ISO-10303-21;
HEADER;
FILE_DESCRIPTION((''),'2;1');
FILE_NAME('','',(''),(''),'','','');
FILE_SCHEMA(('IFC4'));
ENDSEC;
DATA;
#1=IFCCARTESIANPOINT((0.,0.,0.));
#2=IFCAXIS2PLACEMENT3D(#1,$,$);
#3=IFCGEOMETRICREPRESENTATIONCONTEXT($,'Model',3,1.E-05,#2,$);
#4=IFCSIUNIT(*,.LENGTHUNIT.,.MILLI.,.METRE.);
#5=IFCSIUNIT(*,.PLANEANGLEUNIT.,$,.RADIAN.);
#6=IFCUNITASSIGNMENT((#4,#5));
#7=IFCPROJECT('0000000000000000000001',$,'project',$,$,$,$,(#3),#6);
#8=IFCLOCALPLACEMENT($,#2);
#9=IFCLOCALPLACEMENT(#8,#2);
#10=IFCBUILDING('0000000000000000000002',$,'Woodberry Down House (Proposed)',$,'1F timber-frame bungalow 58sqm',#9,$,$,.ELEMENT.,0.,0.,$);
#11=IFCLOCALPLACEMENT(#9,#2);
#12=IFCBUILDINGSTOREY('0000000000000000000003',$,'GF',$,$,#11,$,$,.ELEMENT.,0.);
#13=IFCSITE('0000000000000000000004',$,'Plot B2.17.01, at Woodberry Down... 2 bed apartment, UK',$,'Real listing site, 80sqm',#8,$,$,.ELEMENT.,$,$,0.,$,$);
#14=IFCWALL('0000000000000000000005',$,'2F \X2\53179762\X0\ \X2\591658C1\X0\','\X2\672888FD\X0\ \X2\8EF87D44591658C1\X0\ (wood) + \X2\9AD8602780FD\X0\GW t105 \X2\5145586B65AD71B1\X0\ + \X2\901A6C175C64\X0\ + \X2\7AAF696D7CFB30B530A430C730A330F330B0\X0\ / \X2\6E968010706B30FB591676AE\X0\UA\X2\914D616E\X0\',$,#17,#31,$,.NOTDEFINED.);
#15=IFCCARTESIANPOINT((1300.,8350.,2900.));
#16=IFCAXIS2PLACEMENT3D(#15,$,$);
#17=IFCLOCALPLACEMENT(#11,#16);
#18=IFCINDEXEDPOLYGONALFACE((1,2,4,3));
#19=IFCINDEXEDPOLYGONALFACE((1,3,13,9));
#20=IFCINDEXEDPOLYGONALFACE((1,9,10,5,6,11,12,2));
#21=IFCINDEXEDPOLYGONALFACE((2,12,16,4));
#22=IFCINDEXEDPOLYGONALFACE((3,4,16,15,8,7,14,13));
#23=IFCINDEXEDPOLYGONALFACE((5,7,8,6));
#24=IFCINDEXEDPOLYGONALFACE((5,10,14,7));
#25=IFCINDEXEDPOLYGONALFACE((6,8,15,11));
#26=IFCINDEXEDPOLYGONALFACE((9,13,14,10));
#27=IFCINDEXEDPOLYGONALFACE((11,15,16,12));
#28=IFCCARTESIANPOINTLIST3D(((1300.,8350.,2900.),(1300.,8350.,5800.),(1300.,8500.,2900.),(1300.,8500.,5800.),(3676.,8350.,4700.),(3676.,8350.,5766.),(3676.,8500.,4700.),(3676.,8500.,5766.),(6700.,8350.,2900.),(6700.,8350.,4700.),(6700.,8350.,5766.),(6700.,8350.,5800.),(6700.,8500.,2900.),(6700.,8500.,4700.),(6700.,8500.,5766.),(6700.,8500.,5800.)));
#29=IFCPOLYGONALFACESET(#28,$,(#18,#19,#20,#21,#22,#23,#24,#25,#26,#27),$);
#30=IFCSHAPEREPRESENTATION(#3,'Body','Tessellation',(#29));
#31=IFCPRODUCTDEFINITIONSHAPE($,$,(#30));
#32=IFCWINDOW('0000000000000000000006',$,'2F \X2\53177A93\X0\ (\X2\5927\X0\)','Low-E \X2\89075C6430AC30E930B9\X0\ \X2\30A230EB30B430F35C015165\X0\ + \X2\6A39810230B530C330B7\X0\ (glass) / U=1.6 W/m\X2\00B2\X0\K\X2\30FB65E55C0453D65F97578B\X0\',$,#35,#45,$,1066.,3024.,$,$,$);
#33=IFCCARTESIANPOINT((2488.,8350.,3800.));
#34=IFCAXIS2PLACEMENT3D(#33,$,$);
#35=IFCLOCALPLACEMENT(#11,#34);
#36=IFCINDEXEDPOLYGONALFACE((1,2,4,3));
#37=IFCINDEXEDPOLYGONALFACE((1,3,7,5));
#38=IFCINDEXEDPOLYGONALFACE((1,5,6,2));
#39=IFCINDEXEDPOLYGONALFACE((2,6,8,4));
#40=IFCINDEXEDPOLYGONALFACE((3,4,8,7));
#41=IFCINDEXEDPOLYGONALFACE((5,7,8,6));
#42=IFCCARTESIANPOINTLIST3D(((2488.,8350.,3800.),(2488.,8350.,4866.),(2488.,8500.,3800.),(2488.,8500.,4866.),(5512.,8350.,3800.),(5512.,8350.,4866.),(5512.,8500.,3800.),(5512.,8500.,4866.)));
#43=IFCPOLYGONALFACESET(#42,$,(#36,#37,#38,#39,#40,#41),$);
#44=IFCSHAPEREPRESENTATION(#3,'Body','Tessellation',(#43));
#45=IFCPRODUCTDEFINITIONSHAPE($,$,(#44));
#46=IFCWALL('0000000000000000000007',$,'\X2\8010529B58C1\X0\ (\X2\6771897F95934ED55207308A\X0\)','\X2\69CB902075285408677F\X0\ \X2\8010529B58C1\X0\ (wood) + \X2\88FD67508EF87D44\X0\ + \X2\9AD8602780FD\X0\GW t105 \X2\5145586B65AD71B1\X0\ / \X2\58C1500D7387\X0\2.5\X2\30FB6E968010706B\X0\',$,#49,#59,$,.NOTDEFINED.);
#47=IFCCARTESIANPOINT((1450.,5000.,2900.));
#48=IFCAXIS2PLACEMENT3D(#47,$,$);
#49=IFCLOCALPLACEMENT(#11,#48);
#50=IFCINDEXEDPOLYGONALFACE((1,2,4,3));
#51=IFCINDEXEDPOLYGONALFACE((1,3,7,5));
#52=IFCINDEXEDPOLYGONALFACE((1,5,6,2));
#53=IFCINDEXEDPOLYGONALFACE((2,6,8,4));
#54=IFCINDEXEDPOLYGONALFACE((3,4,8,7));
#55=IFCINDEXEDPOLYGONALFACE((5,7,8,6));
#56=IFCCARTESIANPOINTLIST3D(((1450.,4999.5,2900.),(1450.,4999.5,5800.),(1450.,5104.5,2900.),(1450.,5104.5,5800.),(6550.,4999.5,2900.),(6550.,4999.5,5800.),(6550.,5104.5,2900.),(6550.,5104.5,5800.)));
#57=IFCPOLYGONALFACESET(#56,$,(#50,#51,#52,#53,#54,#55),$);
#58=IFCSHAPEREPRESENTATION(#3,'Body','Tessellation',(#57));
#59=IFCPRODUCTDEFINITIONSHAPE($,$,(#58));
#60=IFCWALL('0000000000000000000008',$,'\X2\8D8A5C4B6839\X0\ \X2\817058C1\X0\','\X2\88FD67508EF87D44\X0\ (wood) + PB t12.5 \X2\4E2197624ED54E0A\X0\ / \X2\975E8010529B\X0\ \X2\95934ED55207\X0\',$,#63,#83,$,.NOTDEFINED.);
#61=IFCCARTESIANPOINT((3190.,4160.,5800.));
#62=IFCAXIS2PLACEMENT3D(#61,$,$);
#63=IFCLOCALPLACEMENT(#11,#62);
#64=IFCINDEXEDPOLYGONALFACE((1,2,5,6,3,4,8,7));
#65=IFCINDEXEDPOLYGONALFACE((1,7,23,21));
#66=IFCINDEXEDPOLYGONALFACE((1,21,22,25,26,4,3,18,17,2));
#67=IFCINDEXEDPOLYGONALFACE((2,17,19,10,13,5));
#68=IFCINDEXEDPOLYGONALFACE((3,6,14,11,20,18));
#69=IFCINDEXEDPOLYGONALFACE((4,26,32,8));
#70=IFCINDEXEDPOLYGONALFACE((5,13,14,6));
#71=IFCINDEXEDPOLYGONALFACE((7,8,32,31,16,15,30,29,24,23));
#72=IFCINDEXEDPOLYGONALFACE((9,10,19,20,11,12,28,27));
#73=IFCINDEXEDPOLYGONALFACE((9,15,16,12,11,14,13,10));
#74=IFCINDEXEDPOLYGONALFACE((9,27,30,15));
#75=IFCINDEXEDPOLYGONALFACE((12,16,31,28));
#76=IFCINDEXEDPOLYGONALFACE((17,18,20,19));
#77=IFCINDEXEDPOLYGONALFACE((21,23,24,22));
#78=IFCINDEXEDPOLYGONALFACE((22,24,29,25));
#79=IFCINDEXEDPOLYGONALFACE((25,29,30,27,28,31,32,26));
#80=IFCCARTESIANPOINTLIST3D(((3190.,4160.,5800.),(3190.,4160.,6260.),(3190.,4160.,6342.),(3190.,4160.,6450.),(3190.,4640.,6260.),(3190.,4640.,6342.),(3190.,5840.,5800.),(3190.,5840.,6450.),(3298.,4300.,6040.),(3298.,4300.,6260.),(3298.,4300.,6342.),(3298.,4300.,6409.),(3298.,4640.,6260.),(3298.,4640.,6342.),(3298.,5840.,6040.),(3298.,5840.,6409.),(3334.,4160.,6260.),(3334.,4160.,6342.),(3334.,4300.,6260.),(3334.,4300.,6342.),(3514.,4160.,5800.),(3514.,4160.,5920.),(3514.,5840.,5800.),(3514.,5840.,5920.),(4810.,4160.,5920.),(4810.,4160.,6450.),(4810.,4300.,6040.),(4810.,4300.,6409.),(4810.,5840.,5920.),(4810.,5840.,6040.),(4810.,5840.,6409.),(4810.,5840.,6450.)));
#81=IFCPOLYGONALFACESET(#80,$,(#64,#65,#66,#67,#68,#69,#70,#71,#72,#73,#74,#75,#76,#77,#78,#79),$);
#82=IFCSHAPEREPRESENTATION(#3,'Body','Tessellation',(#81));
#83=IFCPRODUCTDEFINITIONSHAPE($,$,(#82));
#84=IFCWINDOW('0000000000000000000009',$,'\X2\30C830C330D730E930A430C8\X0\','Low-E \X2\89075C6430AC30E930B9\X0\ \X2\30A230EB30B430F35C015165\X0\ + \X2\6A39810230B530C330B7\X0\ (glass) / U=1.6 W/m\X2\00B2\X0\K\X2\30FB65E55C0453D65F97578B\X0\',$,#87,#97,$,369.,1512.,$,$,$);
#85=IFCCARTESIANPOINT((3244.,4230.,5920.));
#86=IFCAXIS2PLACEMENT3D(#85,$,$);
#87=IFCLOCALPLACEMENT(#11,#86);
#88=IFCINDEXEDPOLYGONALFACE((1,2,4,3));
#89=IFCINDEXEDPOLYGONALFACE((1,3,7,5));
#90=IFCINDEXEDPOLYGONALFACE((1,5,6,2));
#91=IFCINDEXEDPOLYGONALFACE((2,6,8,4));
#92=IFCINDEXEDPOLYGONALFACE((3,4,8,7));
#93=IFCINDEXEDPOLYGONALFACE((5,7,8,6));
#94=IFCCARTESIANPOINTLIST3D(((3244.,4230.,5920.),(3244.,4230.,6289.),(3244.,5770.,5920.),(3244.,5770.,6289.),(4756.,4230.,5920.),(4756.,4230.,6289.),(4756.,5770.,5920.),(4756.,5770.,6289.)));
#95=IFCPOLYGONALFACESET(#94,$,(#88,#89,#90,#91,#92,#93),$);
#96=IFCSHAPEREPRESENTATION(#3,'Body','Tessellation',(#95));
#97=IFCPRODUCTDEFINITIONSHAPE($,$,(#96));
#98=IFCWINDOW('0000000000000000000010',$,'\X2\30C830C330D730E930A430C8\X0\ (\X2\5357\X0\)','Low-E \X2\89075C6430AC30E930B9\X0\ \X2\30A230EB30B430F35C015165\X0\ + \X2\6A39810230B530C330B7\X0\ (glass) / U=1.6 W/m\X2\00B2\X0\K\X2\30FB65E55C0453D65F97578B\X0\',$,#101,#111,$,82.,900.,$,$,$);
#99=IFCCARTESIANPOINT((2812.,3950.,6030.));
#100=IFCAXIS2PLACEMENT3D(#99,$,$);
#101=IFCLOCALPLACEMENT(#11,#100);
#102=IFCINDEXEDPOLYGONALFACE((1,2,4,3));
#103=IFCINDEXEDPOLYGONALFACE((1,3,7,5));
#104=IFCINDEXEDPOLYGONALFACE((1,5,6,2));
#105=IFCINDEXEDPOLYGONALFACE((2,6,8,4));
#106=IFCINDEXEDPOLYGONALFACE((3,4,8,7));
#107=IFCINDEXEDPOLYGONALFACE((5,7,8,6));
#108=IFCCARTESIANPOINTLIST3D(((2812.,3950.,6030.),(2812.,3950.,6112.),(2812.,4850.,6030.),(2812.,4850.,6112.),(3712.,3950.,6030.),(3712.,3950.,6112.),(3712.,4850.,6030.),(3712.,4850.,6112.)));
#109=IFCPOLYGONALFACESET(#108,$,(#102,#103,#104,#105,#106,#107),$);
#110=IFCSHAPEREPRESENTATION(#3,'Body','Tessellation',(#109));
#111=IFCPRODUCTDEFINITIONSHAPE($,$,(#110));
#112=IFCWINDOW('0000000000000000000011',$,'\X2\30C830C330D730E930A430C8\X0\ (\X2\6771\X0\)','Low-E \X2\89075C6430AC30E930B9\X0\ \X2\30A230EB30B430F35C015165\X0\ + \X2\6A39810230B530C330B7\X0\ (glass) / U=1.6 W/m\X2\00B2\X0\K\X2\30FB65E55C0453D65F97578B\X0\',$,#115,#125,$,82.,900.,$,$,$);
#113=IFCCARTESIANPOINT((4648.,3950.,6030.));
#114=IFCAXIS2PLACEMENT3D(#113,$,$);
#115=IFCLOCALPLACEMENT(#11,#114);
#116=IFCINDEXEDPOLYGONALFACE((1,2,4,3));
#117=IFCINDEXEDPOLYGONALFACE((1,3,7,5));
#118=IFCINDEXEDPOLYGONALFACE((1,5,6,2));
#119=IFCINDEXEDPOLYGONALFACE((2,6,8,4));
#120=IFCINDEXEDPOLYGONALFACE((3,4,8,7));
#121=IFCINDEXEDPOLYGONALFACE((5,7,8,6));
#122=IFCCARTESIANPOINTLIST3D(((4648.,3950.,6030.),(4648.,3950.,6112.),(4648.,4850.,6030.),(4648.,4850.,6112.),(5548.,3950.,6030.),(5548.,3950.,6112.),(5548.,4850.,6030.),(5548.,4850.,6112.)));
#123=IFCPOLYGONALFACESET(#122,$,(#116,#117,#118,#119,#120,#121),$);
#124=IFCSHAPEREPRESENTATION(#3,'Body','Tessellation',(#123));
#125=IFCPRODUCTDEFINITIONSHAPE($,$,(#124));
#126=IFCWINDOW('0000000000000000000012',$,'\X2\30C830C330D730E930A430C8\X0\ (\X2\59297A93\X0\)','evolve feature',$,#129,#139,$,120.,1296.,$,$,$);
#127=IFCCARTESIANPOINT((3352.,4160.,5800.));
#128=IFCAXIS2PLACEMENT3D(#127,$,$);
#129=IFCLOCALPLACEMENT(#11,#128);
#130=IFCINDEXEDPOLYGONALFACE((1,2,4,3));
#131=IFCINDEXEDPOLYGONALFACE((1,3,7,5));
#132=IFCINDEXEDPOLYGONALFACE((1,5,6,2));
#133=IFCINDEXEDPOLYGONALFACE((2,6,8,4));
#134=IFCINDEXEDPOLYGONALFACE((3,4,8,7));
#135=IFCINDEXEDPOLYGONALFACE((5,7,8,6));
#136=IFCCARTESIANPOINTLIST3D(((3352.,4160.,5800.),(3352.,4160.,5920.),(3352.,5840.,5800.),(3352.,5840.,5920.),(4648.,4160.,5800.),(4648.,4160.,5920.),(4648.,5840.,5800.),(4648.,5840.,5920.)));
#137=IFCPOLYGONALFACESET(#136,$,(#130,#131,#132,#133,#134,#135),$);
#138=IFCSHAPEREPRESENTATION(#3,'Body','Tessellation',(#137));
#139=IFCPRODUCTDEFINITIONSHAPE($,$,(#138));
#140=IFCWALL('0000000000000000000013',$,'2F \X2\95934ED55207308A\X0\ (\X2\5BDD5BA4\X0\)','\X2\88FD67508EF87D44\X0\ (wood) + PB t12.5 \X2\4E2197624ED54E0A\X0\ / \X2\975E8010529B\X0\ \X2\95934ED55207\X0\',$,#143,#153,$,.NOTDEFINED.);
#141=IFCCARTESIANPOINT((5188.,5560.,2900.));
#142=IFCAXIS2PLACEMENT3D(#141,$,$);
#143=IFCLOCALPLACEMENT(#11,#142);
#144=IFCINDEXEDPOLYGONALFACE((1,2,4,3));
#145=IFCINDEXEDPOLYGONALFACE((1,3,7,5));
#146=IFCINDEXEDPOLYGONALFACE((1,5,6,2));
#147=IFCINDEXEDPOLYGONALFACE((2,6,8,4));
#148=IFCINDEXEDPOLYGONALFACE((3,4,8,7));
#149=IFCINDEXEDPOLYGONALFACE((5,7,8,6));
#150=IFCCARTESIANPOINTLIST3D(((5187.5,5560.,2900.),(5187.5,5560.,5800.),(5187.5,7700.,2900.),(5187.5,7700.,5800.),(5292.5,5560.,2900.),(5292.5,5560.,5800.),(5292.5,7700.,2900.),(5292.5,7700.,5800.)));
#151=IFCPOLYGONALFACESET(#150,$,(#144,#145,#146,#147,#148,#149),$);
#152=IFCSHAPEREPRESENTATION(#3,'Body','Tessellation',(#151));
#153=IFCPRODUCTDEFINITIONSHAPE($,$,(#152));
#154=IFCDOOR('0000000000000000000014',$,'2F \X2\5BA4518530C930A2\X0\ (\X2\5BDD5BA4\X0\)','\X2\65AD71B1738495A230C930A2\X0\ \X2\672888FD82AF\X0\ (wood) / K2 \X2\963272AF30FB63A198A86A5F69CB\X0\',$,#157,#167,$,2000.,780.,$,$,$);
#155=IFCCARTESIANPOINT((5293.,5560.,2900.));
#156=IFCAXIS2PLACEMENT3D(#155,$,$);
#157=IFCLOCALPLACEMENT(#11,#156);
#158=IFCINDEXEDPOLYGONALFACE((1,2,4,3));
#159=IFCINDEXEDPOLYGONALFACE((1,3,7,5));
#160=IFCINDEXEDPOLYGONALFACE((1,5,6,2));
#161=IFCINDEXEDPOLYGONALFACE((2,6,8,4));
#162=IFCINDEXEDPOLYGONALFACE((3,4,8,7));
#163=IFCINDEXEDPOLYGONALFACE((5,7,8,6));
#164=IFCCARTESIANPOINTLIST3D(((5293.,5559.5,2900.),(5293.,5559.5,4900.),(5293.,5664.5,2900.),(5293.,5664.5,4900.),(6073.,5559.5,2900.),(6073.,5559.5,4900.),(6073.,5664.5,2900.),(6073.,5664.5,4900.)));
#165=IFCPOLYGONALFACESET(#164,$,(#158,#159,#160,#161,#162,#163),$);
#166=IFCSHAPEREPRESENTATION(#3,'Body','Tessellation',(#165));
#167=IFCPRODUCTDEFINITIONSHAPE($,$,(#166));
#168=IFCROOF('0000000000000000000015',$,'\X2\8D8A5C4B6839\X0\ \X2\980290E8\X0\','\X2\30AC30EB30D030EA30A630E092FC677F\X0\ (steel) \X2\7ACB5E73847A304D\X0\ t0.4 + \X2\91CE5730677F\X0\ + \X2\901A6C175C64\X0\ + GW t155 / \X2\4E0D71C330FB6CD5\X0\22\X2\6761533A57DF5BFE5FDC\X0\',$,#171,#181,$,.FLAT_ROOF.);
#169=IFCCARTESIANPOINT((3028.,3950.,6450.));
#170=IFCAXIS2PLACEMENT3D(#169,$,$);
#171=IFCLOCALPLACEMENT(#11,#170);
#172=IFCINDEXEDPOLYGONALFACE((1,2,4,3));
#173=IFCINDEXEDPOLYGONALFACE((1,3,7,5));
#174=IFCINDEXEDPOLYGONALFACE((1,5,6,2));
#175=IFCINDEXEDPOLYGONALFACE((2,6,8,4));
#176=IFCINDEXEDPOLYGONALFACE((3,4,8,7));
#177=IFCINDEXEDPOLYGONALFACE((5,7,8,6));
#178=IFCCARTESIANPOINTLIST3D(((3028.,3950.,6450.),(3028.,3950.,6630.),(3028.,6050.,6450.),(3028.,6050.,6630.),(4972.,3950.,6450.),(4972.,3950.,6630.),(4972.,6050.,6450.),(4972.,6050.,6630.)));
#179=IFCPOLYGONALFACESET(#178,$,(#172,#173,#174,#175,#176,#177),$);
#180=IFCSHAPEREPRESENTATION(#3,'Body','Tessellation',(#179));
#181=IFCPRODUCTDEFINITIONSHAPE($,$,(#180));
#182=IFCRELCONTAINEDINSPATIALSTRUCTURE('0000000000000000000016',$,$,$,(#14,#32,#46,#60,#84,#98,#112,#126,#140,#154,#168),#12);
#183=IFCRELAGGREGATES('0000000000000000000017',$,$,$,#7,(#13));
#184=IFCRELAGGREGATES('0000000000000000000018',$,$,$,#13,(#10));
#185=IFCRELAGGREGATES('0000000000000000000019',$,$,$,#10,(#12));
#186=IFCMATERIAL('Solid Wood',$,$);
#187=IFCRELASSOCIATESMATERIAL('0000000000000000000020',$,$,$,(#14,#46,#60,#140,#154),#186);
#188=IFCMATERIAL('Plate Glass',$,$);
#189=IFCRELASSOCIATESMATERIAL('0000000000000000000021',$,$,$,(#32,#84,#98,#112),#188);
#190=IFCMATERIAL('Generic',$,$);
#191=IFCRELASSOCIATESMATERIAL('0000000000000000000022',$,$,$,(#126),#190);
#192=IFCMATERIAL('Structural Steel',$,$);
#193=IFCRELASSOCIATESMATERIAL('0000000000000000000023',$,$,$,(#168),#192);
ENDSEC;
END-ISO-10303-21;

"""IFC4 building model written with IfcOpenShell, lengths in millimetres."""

from ifc_helpers import new_model, si_unit, frame, frame_2d, origin, place, context, project, spatial, rectangle, extrude, material, element, fill, save


model = new_model("IFC4")

# Units and contexts
model_context = context("Model", 3, precision=1e-05, world=origin())
ifc_project = project(units=[si_unit("LENGTHUNIT", "METRE", prefix="MILLI"), si_unit("PLANEANGLEUNIT", "RADIAN")], contexts=[model_context])

# Site, building, storey
site_placement = place(None, origin())
site = spatial("IfcSite", under=ifc_project, at=site_placement, Name="Plot B2.17.01, at Woodberry Down... 2 bed apartment, UK", ObjectType="Real listing site, 80sqm", CompositionType="ELEMENT", RefElevation=0.0)
building_placement = place(site_placement, origin())
building = spatial("IfcBuilding", under=site, at=building_placement, Name="Woodberry Down House (Proposed)", ObjectType="1F timber-frame bungalow 58sqm", CompositionType="ELEMENT", ElevationOfRefHeight=0.0, ElevationOfTerrain=0.0)
storey_placement = place(building_placement, origin())
storey = spatial("IfcBuildingStorey", under=building, at=storey_placement, Name="GF", CompositionType="ELEMENT", Elevation=0.0)

# Wall, opening, window
ifc_material_1 = material(Name="Solid Wood")
wall_1_placement = place(storey_placement, frame((1300.0, 8350.0, 2900.0)))
wall_1 = element("IfcWall", 1, at=wall_1_placement, inside=storey, material=ifc_material_1, Name="2F 北面 外壁", Description="木製 軸組外壁 (wood) + 高性能GW t105 充填断熱 + 通気層 + 窯業系サイディング / 準耐火・外皮UA配慮", PredefinedType="NOTDEFINED", context=model_context, shape_type="SweptSolid", body=[
    extrude(rectangle(XDim=5400.0, YDim=150.0, at=frame_2d((2700.0, 75.0))), frame((1300.0, 8350.0, 2900.0)), (0.0, 0.0, 1.0), 2900.0),
])
opening_1_placement = place(storey_placement, frame((2488.0, 8350.0, 3800.0)))
opening_1 = element("IfcOpeningElement", 2, at=opening_1_placement, cuts=wall_1, PredefinedType="NOTDEFINED", context=model_context, shape_type="SweptSolid", body=[
    extrude(rectangle(XDim=3024.0, YDim=150.0, at=frame_2d((1512.0, 75.0))), frame((2488.0, 8350.0, 3800.0)), (0.0, 0.0, 1.0), 1066.0),
])
ifc_material_2 = material(Name="Plate Glass")
window_1_placement = place(storey_placement, frame((2488.0, 8350.0, 3800.0)))
window_1 = element("IfcWindow", 3, at=window_1_placement, inside=storey, material=ifc_material_2, Name="2F 北窓 (大)", Description="Low-E 複層ガラス アルゴン封入 + 樹脂サッシ (glass) / U=1.6 W/m²K・日射取得型", OverallHeight=1066.0, OverallWidth=3024.0, context=model_context, shape_type="SweptSolid", body=[
    extrude(rectangle(XDim=3024.0, YDim=150.0, at=frame_2d((1512.0, 75.0))), frame((2488.0, 8350.0, 3800.0)), (0.0, 0.0, 1.0), 1066.0),
])
fill(opening_1, window_1)

# Wall
wall_2_placement = place(storey_placement, frame((1450.0, 5000.0, 2900.0)))
element("IfcWall", 4, at=wall_2_placement, inside=storey, material=ifc_material_1, Name="耐力壁 (東西間仕切り)", Description="構造用合板 耐力壁 (wood) + 製材軸組 + 高性能GW t105 充填断熱 / 壁倍率2.5・準耐火", PredefinedType="NOTDEFINED", context=model_context, shape_type="SweptSolid", body=[
    extrude(rectangle(XDim=5100.0, YDim=105.0, at=frame_2d((2550.0, 52.0))), frame((1450.0, 5000.0, 2900.0)), (0.0, 0.0, 1.0), 2900.0),
])

# Wall, openings, windows
wall_3_placement = place(storey_placement, frame((3190.0, 4160.0, 5800.0)))
wall_3 = element("IfcWall", 5, at=wall_3_placement, inside=storey, material=ifc_material_1, Name="越屋根 腰壁", Description="製材軸組 (wood) + PB t12.5 両面仕上 / 非耐力 間仕切", PredefinedType="NOTDEFINED", context=model_context, shape_type="SweptSolid", body=[
    extrude(rectangle(XDim=1620.0, YDim=1680.0, at=frame_2d((810.0, 840.0))), frame((3190.0, 4160.0, 5800.0)), (0.0, 0.0, 1.0), 650.0),
])
opening_2_placement = place(storey_placement, frame((3244.0, 4230.0, 5920.0)))
opening_2 = element("IfcOpeningElement", 6, at=opening_2_placement, cuts=wall_3, PredefinedType="NOTDEFINED", context=model_context, shape_type="SweptSolid", body=[
    extrude(rectangle(XDim=1512.0, YDim=1540.0, at=frame_2d((756.0, 770.0))), frame((3244.0, 4230.0, 5920.0)), (0.0, 0.0, 1.0), 369.0),
])
opening_3_placement = place(storey_placement, frame((2812.0, 3950.0, 6030.0)))
opening_3 = element("IfcOpeningElement", 7, at=opening_3_placement, cuts=wall_3, PredefinedType="NOTDEFINED", context=model_context, shape_type="SweptSolid", body=[
    extrude(rectangle(XDim=900.0, YDim=900.0, at=frame_2d((450.0, 450.0))), frame((2812.0, 3950.0, 6030.0)), (0.0, 0.0, 1.0), 82.0),
])
opening_4_placement = place(storey_placement, frame((4648.0, 3950.0, 6030.0)))
opening_4 = element("IfcOpeningElement", 8, at=opening_4_placement, cuts=wall_3, PredefinedType="NOTDEFINED", context=model_context, shape_type="SweptSolid", body=[
    extrude(rectangle(XDim=900.0, YDim=900.0, at=frame_2d((450.0, 450.0))), frame((4648.0, 3950.0, 6030.0)), (0.0, 0.0, 1.0), 82.0),
])
opening_5_placement = place(storey_placement, frame((3352.0, 4160.0, 5800.0)))
opening_5 = element("IfcOpeningElement", 9, at=opening_5_placement, cuts=wall_3, PredefinedType="NOTDEFINED", context=model_context, shape_type="SweptSolid", body=[
    extrude(rectangle(XDim=1296.0, YDim=1680.0, at=frame_2d((648.0, 840.0))), frame((3352.0, 4160.0, 5800.0)), (0.0, 0.0, 1.0), 120.0),
])
window_2_placement = place(storey_placement, frame((3244.0, 4230.0, 5920.0)))
window_2 = element("IfcWindow", 10, at=window_2_placement, inside=storey, material=ifc_material_2, Name="トップライト", Description="Low-E 複層ガラス アルゴン封入 + 樹脂サッシ (glass) / U=1.6 W/m²K・日射取得型", OverallHeight=369.0, OverallWidth=1512.0, context=model_context, shape_type="SweptSolid", body=[
    extrude(rectangle(XDim=1512.0, YDim=1540.0, at=frame_2d((756.0, 770.0))), frame((3244.0, 4230.0, 5920.0)), (0.0, 0.0, 1.0), 369.0),
])
fill(opening_2, window_2)
window_3_placement = place(storey_placement, frame((2812.0, 3950.0, 6030.0)))
window_3 = element("IfcWindow", 11, at=window_3_placement, inside=storey, material=ifc_material_2, Name="トップライト (南)", Description="Low-E 複層ガラス アルゴン封入 + 樹脂サッシ (glass) / U=1.6 W/m²K・日射取得型", OverallHeight=82.0, OverallWidth=900.0, context=model_context, shape_type="SweptSolid", body=[
    extrude(rectangle(XDim=900.0, YDim=900.0, at=frame_2d((450.0, 450.0))), frame((2812.0, 3950.0, 6030.0)), (0.0, 0.0, 1.0), 82.0),
])
fill(opening_3, window_3)
window_4_placement = place(storey_placement, frame((4648.0, 3950.0, 6030.0)))
window_4 = element("IfcWindow", 12, at=window_4_placement, inside=storey, material=ifc_material_2, Name="トップライト (東)", Description="Low-E 複層ガラス アルゴン封入 + 樹脂サッシ (glass) / U=1.6 W/m²K・日射取得型", OverallHeight=82.0, OverallWidth=900.0, context=model_context, shape_type="SweptSolid", body=[
    extrude(rectangle(XDim=900.0, YDim=900.0, at=frame_2d((450.0, 450.0))), frame((4648.0, 3950.0, 6030.0)), (0.0, 0.0, 1.0), 82.0),
])
fill(opening_4, window_4)
ifc_material_3 = material(Name="Generic")
window_5_placement = place(storey_placement, frame((3352.0, 4160.0, 5800.0)))
window_5 = element("IfcWindow", 13, at=window_5_placement, inside=storey, material=ifc_material_3, Name="トップライト (天窓)", Description="evolve feature", OverallHeight=120.0, OverallWidth=1296.0, context=model_context, shape_type="SweptSolid", body=[
    extrude(rectangle(XDim=1296.0, YDim=1680.0, at=frame_2d((648.0, 840.0))), frame((3352.0, 4160.0, 5800.0)), (0.0, 0.0, 1.0), 120.0),
])
fill(opening_5, window_5)

# Wall
wall_4_placement = place(storey_placement, frame((5188.0, 5560.0, 2900.0)))
element("IfcWall", 14, at=wall_4_placement, inside=storey, material=ifc_material_1, Name="2F 間仕切り (寝室)", Description="製材軸組 (wood) + PB t12.5 両面仕上 / 非耐力 間仕切", PredefinedType="NOTDEFINED", context=model_context, shape_type="SweptSolid", body=[
    extrude(rectangle(XDim=105.0, YDim=2140.0, at=frame_2d((52.0, 1070.0))), frame((5188.0, 5560.0, 2900.0)), (0.0, 0.0, 1.0), 2900.0),
])

# Door
door_placement = place(storey_placement, frame((5293.0, 5560.0, 2900.0)))
element("IfcDoor", 15, at=door_placement, inside=storey, material=ifc_material_1, Name="2F 室内ドア (寝室)", Description="断熱玄関ドア 木製芯 (wood) / K2 防犯・採風機構", OverallHeight=2000.0, OverallWidth=780.0, context=model_context, shape_type="SweptSolid", body=[
    extrude(rectangle(XDim=780.0, YDim=105.0, at=frame_2d((390.0, 52.0))), frame((5293.0, 5560.0, 2900.0)), (0.0, 0.0, 1.0), 2000.0),
])

# Roof
ifc_material_4 = material(Name="Structural Steel")
roof_placement = place(storey_placement, frame((3028.0, 3950.0, 6450.0)))
element("IfcRoof", 16, at=roof_placement, inside=storey, material=ifc_material_4, Name="越屋根 頂部", Description="ガルバリウム鋼板 (steel) 立平葺き t0.4 + 野地板 + 通気層 + GW t155 / 不燃・法22条区域対応", PredefinedType="FLAT_ROOF", context=model_context, shape_type="SweptSolid", body=[
    extrude(rectangle(XDim=1944.0, YDim=2100.0, at=frame_2d((972.0, 1050.0))), frame((3028.0, 3950.0, 6450.0)), (0.0, 0.0, 1.0), 180.0),
])

save(model, "model.ifc")
